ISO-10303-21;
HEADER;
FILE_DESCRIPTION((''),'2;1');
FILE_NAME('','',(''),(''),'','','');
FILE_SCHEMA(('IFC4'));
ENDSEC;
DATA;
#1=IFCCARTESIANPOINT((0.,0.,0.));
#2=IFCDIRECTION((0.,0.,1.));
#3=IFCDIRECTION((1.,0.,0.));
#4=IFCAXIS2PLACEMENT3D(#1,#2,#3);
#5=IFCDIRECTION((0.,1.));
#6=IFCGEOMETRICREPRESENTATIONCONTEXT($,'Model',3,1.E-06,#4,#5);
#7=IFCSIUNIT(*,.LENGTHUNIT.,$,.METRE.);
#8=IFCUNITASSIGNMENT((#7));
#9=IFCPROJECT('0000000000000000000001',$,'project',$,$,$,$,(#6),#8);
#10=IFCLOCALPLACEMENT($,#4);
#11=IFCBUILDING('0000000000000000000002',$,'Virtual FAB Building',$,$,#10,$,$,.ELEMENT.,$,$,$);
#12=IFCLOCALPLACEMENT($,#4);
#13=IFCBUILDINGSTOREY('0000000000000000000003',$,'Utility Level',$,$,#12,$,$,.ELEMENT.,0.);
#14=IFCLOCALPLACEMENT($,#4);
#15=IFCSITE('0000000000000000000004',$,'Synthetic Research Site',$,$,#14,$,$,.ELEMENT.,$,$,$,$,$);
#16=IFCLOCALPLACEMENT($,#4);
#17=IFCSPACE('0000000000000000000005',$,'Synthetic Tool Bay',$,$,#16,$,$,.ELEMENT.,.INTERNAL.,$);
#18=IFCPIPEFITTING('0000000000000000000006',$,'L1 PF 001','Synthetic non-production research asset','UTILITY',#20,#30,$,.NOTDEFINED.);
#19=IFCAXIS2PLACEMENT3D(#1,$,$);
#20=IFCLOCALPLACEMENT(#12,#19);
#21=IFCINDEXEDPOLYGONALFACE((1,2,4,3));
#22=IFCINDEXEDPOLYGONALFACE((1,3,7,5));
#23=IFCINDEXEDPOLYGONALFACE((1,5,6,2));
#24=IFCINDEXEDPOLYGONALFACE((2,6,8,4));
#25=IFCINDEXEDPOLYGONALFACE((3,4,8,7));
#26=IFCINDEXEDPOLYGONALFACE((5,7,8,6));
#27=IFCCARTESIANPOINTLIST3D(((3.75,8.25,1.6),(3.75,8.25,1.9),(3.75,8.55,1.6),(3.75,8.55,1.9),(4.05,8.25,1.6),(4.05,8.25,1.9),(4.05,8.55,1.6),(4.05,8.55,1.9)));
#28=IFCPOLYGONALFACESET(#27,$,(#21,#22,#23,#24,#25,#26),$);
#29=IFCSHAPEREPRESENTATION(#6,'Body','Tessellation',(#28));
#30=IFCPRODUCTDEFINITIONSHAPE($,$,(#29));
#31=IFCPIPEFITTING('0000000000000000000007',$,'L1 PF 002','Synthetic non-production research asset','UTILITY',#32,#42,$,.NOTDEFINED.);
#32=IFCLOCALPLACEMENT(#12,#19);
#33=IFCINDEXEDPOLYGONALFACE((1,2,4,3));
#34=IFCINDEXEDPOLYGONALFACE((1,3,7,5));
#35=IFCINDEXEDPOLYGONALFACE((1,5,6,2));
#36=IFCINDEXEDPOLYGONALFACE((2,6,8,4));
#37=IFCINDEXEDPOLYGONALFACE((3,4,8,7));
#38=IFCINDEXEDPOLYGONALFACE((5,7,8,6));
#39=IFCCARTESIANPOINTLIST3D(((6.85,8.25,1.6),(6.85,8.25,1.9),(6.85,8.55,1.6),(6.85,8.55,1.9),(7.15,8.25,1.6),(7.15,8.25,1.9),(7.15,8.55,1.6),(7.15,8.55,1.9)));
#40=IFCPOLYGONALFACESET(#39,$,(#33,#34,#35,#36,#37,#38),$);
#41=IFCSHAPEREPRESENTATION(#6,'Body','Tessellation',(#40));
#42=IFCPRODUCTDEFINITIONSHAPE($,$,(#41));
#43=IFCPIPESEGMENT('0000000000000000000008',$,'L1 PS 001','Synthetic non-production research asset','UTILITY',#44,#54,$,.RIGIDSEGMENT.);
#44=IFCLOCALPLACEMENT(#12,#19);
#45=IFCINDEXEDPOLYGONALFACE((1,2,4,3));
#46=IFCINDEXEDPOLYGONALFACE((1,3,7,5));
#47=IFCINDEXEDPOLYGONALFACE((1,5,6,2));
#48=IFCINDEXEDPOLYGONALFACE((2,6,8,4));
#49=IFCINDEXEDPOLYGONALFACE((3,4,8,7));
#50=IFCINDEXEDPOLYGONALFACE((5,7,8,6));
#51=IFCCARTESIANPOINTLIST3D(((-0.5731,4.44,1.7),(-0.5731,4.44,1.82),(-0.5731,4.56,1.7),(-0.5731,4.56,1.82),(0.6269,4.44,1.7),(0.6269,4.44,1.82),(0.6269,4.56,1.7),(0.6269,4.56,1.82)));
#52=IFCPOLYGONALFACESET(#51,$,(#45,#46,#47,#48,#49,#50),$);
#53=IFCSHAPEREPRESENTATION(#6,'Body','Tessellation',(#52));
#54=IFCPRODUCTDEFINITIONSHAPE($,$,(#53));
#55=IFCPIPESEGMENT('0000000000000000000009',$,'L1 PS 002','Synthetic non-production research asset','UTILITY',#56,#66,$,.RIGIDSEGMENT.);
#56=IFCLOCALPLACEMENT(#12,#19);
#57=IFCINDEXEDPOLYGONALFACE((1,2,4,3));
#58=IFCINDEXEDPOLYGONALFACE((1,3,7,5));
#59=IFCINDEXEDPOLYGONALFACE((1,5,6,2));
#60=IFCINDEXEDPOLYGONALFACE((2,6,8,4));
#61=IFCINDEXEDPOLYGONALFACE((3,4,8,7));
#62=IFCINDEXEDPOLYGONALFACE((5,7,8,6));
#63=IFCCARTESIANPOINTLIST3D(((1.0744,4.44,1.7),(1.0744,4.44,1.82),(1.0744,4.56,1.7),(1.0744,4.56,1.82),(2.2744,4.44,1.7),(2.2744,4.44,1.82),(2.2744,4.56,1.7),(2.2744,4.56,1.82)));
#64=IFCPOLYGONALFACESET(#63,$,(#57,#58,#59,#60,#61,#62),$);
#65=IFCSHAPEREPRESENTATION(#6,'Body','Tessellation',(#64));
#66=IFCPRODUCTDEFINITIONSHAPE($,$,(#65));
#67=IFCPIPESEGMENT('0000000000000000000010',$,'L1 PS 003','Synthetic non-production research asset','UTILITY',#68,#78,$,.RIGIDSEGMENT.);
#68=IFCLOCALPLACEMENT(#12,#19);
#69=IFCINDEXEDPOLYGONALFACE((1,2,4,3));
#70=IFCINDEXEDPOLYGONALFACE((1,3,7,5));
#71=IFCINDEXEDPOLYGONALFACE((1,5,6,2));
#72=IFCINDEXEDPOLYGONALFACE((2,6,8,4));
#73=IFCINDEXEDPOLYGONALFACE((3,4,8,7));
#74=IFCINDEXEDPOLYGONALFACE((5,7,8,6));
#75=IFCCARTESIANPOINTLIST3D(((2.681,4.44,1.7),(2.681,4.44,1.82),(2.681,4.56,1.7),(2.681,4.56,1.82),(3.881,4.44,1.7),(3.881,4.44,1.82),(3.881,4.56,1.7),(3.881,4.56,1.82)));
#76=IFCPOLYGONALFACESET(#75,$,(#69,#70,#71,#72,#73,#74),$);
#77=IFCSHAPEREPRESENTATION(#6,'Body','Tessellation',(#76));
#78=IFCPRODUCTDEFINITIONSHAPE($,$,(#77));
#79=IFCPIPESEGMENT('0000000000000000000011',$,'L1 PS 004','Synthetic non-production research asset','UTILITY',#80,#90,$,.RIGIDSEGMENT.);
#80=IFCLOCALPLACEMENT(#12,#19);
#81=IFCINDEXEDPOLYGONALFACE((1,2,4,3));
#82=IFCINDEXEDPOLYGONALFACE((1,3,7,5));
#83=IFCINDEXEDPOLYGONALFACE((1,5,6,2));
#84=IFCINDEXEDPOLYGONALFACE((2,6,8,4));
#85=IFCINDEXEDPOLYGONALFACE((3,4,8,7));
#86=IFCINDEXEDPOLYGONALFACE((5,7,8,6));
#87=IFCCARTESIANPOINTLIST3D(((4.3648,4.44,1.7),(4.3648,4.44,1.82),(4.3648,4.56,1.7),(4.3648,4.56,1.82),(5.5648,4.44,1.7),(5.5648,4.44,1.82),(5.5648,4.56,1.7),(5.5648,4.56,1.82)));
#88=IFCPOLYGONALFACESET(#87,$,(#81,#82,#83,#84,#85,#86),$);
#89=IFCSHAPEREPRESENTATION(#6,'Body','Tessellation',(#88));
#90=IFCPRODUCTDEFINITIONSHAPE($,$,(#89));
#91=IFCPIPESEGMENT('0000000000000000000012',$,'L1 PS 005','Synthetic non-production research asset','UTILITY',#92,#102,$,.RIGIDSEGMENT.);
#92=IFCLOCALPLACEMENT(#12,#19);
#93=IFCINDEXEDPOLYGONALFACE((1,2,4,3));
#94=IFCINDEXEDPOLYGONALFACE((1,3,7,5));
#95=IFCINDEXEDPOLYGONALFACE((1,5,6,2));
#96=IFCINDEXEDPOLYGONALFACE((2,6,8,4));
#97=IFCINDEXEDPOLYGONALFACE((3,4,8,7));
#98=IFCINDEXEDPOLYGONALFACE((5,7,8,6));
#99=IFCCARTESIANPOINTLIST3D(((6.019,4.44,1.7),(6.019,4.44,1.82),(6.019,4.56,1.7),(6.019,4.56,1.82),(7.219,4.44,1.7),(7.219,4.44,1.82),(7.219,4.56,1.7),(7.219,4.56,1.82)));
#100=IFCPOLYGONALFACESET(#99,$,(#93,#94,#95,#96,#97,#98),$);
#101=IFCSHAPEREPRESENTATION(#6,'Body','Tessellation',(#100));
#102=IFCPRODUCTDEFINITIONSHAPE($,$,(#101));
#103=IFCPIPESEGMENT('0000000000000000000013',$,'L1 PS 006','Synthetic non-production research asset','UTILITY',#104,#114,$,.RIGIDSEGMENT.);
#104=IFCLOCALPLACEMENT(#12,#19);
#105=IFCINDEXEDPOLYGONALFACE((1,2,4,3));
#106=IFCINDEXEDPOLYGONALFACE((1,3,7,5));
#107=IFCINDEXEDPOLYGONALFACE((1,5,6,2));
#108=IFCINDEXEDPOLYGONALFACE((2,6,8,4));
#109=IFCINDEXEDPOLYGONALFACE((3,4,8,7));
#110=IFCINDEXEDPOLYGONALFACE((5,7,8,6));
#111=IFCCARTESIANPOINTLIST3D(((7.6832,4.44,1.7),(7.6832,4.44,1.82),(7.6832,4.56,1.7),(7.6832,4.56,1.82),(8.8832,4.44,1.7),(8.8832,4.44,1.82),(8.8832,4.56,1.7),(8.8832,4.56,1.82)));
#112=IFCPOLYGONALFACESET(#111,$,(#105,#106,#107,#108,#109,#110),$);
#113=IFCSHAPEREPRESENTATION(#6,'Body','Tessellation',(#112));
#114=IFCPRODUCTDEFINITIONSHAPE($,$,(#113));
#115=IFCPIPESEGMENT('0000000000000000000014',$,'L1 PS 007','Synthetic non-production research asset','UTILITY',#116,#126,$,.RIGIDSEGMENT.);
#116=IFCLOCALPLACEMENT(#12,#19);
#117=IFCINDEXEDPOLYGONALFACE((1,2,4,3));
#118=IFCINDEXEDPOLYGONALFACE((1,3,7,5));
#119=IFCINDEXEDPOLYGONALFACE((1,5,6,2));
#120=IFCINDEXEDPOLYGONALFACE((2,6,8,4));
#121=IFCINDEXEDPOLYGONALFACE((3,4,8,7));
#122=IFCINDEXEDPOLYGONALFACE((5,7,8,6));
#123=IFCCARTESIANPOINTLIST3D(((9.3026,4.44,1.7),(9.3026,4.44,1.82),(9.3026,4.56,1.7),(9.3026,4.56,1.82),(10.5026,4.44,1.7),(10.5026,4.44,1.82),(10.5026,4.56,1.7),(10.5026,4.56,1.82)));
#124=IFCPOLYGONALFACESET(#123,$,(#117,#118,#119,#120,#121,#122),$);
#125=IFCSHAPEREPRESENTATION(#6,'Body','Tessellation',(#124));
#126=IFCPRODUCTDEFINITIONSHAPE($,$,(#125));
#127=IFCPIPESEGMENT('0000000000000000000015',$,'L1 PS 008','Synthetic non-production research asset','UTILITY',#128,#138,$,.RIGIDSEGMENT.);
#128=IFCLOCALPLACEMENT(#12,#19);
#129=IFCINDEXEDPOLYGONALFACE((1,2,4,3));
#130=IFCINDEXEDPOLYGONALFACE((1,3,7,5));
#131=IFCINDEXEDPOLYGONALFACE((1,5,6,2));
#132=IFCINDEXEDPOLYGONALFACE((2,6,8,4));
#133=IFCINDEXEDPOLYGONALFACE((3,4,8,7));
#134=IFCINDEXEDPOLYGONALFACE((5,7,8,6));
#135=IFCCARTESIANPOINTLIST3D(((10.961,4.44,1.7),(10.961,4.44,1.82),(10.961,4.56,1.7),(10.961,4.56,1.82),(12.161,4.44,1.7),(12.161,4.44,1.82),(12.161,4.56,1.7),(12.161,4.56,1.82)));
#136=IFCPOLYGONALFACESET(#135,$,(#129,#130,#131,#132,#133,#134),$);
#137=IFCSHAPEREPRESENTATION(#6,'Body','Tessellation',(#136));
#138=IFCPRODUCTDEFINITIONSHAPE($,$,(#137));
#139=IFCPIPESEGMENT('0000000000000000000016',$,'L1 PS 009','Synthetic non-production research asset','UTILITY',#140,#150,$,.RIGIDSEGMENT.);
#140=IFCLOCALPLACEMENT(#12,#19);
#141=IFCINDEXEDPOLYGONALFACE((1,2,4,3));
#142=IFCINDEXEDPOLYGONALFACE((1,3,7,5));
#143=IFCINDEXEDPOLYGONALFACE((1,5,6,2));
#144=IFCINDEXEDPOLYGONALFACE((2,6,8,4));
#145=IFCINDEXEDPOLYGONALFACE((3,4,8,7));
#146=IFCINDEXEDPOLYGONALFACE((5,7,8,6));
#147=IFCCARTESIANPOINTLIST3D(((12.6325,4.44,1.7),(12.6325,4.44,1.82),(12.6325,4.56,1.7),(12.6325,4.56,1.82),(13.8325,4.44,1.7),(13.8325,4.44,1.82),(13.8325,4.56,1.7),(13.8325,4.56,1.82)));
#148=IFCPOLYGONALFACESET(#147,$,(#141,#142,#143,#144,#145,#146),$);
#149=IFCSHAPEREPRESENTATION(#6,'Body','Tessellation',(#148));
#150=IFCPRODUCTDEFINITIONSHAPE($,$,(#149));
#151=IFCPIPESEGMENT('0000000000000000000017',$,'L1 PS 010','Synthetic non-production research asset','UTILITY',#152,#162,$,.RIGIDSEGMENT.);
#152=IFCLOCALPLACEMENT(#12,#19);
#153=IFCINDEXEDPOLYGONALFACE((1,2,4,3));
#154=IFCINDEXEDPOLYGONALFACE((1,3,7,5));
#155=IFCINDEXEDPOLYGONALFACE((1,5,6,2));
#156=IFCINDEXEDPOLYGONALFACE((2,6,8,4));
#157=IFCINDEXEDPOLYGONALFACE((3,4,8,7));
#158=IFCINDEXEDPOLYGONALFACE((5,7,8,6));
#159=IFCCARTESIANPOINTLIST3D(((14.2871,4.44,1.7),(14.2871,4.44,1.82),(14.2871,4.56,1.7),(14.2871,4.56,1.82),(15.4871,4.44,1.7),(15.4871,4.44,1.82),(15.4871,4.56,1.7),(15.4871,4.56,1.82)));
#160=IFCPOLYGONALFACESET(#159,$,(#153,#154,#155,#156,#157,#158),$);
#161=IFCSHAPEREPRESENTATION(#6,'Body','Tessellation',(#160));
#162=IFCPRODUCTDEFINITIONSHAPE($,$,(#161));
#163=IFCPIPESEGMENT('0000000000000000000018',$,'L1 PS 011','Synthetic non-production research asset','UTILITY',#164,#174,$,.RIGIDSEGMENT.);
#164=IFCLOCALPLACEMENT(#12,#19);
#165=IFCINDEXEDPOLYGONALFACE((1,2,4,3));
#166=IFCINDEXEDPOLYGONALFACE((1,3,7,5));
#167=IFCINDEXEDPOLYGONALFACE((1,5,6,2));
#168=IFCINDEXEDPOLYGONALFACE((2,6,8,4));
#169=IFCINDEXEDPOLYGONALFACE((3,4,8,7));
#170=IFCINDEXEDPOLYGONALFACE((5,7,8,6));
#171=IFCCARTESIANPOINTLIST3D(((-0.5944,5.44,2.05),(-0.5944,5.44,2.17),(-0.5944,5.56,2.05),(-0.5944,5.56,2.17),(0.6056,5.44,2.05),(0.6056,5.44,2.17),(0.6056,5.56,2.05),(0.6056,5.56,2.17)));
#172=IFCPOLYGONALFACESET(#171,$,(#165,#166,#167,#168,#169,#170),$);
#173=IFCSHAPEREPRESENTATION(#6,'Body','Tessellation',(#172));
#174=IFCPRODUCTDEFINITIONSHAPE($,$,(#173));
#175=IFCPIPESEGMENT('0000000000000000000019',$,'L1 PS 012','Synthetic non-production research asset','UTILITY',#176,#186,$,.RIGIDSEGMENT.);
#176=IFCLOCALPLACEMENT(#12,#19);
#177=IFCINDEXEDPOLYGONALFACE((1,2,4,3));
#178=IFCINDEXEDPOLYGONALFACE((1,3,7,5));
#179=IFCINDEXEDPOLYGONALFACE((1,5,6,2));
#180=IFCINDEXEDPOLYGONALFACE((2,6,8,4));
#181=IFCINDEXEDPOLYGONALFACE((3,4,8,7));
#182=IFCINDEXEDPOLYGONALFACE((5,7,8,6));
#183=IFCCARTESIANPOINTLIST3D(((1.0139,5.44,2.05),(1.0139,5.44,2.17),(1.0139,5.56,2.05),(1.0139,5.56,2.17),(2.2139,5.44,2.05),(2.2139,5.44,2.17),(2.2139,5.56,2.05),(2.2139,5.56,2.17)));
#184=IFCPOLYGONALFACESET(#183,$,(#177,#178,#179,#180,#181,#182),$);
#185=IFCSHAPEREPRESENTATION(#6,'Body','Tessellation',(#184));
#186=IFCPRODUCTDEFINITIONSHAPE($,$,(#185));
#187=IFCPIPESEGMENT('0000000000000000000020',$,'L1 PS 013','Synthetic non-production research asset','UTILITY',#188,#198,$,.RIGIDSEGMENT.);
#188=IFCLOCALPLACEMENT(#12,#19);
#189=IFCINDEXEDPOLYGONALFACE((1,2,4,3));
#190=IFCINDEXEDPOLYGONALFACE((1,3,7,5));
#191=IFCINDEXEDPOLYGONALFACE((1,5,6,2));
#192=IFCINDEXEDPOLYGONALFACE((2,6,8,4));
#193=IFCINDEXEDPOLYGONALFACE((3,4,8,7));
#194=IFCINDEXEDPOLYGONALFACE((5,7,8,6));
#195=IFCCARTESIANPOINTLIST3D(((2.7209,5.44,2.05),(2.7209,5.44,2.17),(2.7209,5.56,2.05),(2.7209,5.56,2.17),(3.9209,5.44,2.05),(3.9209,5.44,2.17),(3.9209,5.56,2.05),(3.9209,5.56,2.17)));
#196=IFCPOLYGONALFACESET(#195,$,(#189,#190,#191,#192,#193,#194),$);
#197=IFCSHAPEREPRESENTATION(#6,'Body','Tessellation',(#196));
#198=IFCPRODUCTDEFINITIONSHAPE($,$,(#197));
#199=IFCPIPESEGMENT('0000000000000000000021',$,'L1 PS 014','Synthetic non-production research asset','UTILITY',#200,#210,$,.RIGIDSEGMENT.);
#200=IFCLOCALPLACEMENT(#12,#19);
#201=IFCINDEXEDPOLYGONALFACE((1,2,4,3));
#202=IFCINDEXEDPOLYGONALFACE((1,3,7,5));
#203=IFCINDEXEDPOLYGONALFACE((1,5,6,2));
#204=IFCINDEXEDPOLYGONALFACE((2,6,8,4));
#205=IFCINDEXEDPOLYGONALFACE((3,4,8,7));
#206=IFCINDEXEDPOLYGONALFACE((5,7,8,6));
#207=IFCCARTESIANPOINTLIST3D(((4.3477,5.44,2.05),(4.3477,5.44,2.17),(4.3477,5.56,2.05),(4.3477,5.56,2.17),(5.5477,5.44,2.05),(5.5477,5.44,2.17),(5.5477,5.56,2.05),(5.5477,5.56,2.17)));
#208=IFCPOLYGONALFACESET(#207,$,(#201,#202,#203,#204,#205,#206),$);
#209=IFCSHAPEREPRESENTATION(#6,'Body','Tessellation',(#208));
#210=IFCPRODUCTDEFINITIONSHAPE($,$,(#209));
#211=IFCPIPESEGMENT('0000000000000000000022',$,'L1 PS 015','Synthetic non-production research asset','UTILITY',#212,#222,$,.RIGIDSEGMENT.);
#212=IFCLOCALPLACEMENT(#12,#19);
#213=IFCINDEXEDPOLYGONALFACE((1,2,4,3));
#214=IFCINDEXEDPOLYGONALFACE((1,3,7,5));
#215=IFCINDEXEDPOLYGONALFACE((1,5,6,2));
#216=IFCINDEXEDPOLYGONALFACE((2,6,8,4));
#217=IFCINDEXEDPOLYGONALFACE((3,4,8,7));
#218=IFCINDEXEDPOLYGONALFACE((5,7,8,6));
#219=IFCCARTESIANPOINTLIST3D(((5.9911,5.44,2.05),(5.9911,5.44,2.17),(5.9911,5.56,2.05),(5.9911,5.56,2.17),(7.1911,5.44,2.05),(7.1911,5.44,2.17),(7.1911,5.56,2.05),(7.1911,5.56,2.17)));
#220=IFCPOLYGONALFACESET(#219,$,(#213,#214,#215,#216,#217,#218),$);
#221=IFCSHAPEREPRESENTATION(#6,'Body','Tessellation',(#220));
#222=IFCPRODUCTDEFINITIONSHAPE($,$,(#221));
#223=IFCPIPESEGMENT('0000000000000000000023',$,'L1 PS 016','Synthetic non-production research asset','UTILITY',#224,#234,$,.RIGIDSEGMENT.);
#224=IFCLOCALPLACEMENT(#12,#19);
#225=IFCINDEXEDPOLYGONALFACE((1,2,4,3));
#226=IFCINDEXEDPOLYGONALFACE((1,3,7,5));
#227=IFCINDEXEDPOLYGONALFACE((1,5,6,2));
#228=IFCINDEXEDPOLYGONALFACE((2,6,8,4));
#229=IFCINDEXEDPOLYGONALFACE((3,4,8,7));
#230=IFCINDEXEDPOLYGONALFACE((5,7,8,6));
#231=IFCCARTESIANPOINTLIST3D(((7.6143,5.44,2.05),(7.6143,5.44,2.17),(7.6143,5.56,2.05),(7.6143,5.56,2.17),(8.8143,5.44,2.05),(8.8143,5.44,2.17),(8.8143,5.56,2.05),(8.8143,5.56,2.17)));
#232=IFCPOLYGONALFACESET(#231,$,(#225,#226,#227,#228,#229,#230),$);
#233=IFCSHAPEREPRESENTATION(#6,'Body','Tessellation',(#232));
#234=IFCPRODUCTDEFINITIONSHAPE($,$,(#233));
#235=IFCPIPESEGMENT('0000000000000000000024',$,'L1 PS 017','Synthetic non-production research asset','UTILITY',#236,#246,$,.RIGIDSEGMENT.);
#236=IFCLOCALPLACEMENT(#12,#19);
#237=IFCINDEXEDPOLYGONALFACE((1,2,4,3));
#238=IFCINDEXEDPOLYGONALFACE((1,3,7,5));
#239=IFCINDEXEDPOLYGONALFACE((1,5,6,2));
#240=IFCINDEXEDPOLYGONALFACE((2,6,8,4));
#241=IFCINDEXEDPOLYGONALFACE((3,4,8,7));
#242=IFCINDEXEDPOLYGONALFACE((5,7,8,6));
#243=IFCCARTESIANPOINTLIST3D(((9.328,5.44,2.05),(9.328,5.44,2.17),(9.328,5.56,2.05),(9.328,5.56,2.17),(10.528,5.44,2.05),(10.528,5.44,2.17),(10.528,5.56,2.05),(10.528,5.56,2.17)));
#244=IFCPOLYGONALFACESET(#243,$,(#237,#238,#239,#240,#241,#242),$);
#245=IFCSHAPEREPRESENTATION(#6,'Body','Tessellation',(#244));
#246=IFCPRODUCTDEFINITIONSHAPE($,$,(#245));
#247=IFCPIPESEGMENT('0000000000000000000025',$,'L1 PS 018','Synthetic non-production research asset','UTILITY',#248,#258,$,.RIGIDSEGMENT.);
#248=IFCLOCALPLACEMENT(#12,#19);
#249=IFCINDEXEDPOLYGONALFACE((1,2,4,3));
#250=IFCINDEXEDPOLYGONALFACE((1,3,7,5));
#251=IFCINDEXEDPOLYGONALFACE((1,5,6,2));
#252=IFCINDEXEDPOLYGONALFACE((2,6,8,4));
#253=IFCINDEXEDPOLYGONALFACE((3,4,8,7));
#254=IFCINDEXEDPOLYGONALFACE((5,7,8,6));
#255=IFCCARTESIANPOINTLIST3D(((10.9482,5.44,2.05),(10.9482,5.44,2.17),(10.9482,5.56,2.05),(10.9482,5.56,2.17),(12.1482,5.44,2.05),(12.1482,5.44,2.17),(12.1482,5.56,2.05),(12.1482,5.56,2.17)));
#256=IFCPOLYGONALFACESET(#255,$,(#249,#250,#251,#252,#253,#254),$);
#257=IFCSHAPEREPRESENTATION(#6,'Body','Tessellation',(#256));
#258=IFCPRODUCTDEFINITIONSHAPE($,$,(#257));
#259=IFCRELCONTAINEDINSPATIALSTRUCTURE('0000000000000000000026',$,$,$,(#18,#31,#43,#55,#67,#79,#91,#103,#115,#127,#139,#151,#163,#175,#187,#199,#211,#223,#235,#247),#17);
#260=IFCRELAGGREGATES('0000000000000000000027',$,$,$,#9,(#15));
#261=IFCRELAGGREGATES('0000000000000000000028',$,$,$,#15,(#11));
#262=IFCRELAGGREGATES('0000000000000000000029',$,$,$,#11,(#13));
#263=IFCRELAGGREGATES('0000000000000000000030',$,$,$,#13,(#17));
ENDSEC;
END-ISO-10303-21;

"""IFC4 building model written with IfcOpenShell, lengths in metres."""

from ifc_helpers import new_model, si_unit, direction, frame, origin_with_axes, origin_2d_with_axis, place, context, project, spatial, rectangle, extrude, element, save


model = new_model("IFC4")

# Units and contexts
model_context = context("Model", 3, precision=1e-06, world=origin_with_axes(), true_north=direction((0.0, 1.0)))
ifc_project = project(units=[si_unit("LENGTHUNIT", "METRE")], contexts=[model_context])

# Site, building, storey, space
site_placement = place(None, origin_with_axes())
site = spatial("IfcSite", under=ifc_project, at=site_placement, Name="Synthetic Research Site", CompositionType="ELEMENT")
building_placement = place(None, origin_with_axes())
building = spatial("IfcBuilding", under=site, at=building_placement, Name="Virtual FAB Building", CompositionType="ELEMENT")
storey_placement = place(None, origin_with_axes())
storey = spatial("IfcBuildingStorey", under=building, at=storey_placement, Name="Utility Level", CompositionType="ELEMENT", Elevation=0.0)
space_placement = place(None, origin_with_axes())
space = spatial("IfcSpace", under=storey, at=space_placement, Name="Synthetic Tool Bay", CompositionType="ELEMENT", PredefinedType="INTERNAL")

# Pipe fittings
for number, where, z_axis, x_axis, name in (
    (1, (3.9, 8.4, 1.6), (0.0, 0.0, 1.0), (1.0, 0.0, 0.0), "L1 PF 001"),
    (2, (7.0, 8.4, 1.6), (0.0, 0.0, 1.0), (1.0, 0.0, 0.0), "L1 PF 002"),
):
    element("IfcPipeFitting", number, at=place(None, frame(where, z_axis=z_axis, x_axis=x_axis)), inside=space, Name=name, Description="Synthetic non-production research asset", ObjectType="UTILITY", PredefinedType="NOTDEFINED", context=model_context, shape_type="SweptSolid", body=[
        extrude(rectangle(XDim=0.3, YDim=0.3, at=origin_2d_with_axis()), origin_with_axes(), (0.0, 0.0, 1.0), 0.3),
    ])

# Pipe segments
for number, where, z_axis, x_axis, name in (
    (3, (0.0269, 4.5, 1.7), (0.0, 0.0, 1.0), (1.0, 0.0, 0.0), "L1 PS 001"),
    (4, (1.6744, 4.5, 1.7), (0.0, 0.0, 1.0), (1.0, 0.0, 0.0), "L1 PS 002"),
    (5, (3.281, 4.5, 1.7), (0.0, 0.0, 1.0), (1.0, 0.0, 0.0), "L1 PS 003"),
    (6, (4.9648, 4.5, 1.7), (0.0, 0.0, 1.0), (1.0, 0.0, 0.0), "L1 PS 004"),
    (7, (6.619, 4.5, 1.7), (0.0, 0.0, 1.0), (1.0, 0.0, 0.0), "L1 PS 005"),
    (8, (8.2832, 4.5, 1.7), (0.0, 0.0, 1.0), (1.0, 0.0, 0.0), "L1 PS 006"),
    (9, (9.9026, 4.5, 1.7), (0.0, 0.0, 1.0), (1.0, 0.0, 0.0), "L1 PS 007"),
    (10, (11.561, 4.5, 1.7), (0.0, 0.0, 1.0), (1.0, 0.0, 0.0), "L1 PS 008"),
    (11, (13.2325, 4.5, 1.7), (0.0, 0.0, 1.0), (1.0, 0.0, 0.0), "L1 PS 009"),
    (12, (14.8871, 4.5, 1.7), (0.0, 0.0, 1.0), (1.0, 0.0, 0.0), "L1 PS 010"),
    (13, (0.0056, 5.5, 2.05), (0.0, 0.0, 1.0), (1.0, 0.0, 0.0), "L1 PS 011"),
    (14, (1.6139, 5.5, 2.05), (0.0, 0.0, 1.0), (1.0, 0.0, 0.0), "L1 PS 012"),
    (15, (3.3209, 5.5, 2.05), (0.0, 0.0, 1.0), (1.0, 0.0, 0.0), "L1 PS 013"),
    (16, (4.9477, 5.5, 2.05), (0.0, 0.0, 1.0), (1.0, 0.0, 0.0), "L1 PS 014"),
    (17, (6.5911, 5.5, 2.05), (0.0, 0.0, 1.0), (1.0, 0.0, 0.0), "L1 PS 015"),
    (18, (8.2143, 5.5, 2.05), (0.0, 0.0, 1.0), (1.0, 0.0, 0.0), "L1 PS 016"),
    (19, (9.928, 5.5, 2.05), (0.0, 0.0, 1.0), (1.0, 0.0, 0.0), "L1 PS 017"),
    (20, (11.5482, 5.5, 2.05), (0.0, 0.0, 1.0), (1.0, 0.0, 0.0), "L1 PS 018"),
):
    element("IfcPipeSegment", number, at=place(None, frame(where, z_axis=z_axis, x_axis=x_axis)), inside=space, Name=name, Description="Synthetic non-production research asset", ObjectType="UTILITY", PredefinedType="RIGIDSEGMENT", context=model_context, shape_type="SweptSolid", body=[
        extrude(rectangle(XDim=1.2, YDim=0.12, at=origin_2d_with_axis()), origin_with_axes(), (0.0, 0.0, 1.0), 0.12),
    ])

save(model, "model.ifc")
